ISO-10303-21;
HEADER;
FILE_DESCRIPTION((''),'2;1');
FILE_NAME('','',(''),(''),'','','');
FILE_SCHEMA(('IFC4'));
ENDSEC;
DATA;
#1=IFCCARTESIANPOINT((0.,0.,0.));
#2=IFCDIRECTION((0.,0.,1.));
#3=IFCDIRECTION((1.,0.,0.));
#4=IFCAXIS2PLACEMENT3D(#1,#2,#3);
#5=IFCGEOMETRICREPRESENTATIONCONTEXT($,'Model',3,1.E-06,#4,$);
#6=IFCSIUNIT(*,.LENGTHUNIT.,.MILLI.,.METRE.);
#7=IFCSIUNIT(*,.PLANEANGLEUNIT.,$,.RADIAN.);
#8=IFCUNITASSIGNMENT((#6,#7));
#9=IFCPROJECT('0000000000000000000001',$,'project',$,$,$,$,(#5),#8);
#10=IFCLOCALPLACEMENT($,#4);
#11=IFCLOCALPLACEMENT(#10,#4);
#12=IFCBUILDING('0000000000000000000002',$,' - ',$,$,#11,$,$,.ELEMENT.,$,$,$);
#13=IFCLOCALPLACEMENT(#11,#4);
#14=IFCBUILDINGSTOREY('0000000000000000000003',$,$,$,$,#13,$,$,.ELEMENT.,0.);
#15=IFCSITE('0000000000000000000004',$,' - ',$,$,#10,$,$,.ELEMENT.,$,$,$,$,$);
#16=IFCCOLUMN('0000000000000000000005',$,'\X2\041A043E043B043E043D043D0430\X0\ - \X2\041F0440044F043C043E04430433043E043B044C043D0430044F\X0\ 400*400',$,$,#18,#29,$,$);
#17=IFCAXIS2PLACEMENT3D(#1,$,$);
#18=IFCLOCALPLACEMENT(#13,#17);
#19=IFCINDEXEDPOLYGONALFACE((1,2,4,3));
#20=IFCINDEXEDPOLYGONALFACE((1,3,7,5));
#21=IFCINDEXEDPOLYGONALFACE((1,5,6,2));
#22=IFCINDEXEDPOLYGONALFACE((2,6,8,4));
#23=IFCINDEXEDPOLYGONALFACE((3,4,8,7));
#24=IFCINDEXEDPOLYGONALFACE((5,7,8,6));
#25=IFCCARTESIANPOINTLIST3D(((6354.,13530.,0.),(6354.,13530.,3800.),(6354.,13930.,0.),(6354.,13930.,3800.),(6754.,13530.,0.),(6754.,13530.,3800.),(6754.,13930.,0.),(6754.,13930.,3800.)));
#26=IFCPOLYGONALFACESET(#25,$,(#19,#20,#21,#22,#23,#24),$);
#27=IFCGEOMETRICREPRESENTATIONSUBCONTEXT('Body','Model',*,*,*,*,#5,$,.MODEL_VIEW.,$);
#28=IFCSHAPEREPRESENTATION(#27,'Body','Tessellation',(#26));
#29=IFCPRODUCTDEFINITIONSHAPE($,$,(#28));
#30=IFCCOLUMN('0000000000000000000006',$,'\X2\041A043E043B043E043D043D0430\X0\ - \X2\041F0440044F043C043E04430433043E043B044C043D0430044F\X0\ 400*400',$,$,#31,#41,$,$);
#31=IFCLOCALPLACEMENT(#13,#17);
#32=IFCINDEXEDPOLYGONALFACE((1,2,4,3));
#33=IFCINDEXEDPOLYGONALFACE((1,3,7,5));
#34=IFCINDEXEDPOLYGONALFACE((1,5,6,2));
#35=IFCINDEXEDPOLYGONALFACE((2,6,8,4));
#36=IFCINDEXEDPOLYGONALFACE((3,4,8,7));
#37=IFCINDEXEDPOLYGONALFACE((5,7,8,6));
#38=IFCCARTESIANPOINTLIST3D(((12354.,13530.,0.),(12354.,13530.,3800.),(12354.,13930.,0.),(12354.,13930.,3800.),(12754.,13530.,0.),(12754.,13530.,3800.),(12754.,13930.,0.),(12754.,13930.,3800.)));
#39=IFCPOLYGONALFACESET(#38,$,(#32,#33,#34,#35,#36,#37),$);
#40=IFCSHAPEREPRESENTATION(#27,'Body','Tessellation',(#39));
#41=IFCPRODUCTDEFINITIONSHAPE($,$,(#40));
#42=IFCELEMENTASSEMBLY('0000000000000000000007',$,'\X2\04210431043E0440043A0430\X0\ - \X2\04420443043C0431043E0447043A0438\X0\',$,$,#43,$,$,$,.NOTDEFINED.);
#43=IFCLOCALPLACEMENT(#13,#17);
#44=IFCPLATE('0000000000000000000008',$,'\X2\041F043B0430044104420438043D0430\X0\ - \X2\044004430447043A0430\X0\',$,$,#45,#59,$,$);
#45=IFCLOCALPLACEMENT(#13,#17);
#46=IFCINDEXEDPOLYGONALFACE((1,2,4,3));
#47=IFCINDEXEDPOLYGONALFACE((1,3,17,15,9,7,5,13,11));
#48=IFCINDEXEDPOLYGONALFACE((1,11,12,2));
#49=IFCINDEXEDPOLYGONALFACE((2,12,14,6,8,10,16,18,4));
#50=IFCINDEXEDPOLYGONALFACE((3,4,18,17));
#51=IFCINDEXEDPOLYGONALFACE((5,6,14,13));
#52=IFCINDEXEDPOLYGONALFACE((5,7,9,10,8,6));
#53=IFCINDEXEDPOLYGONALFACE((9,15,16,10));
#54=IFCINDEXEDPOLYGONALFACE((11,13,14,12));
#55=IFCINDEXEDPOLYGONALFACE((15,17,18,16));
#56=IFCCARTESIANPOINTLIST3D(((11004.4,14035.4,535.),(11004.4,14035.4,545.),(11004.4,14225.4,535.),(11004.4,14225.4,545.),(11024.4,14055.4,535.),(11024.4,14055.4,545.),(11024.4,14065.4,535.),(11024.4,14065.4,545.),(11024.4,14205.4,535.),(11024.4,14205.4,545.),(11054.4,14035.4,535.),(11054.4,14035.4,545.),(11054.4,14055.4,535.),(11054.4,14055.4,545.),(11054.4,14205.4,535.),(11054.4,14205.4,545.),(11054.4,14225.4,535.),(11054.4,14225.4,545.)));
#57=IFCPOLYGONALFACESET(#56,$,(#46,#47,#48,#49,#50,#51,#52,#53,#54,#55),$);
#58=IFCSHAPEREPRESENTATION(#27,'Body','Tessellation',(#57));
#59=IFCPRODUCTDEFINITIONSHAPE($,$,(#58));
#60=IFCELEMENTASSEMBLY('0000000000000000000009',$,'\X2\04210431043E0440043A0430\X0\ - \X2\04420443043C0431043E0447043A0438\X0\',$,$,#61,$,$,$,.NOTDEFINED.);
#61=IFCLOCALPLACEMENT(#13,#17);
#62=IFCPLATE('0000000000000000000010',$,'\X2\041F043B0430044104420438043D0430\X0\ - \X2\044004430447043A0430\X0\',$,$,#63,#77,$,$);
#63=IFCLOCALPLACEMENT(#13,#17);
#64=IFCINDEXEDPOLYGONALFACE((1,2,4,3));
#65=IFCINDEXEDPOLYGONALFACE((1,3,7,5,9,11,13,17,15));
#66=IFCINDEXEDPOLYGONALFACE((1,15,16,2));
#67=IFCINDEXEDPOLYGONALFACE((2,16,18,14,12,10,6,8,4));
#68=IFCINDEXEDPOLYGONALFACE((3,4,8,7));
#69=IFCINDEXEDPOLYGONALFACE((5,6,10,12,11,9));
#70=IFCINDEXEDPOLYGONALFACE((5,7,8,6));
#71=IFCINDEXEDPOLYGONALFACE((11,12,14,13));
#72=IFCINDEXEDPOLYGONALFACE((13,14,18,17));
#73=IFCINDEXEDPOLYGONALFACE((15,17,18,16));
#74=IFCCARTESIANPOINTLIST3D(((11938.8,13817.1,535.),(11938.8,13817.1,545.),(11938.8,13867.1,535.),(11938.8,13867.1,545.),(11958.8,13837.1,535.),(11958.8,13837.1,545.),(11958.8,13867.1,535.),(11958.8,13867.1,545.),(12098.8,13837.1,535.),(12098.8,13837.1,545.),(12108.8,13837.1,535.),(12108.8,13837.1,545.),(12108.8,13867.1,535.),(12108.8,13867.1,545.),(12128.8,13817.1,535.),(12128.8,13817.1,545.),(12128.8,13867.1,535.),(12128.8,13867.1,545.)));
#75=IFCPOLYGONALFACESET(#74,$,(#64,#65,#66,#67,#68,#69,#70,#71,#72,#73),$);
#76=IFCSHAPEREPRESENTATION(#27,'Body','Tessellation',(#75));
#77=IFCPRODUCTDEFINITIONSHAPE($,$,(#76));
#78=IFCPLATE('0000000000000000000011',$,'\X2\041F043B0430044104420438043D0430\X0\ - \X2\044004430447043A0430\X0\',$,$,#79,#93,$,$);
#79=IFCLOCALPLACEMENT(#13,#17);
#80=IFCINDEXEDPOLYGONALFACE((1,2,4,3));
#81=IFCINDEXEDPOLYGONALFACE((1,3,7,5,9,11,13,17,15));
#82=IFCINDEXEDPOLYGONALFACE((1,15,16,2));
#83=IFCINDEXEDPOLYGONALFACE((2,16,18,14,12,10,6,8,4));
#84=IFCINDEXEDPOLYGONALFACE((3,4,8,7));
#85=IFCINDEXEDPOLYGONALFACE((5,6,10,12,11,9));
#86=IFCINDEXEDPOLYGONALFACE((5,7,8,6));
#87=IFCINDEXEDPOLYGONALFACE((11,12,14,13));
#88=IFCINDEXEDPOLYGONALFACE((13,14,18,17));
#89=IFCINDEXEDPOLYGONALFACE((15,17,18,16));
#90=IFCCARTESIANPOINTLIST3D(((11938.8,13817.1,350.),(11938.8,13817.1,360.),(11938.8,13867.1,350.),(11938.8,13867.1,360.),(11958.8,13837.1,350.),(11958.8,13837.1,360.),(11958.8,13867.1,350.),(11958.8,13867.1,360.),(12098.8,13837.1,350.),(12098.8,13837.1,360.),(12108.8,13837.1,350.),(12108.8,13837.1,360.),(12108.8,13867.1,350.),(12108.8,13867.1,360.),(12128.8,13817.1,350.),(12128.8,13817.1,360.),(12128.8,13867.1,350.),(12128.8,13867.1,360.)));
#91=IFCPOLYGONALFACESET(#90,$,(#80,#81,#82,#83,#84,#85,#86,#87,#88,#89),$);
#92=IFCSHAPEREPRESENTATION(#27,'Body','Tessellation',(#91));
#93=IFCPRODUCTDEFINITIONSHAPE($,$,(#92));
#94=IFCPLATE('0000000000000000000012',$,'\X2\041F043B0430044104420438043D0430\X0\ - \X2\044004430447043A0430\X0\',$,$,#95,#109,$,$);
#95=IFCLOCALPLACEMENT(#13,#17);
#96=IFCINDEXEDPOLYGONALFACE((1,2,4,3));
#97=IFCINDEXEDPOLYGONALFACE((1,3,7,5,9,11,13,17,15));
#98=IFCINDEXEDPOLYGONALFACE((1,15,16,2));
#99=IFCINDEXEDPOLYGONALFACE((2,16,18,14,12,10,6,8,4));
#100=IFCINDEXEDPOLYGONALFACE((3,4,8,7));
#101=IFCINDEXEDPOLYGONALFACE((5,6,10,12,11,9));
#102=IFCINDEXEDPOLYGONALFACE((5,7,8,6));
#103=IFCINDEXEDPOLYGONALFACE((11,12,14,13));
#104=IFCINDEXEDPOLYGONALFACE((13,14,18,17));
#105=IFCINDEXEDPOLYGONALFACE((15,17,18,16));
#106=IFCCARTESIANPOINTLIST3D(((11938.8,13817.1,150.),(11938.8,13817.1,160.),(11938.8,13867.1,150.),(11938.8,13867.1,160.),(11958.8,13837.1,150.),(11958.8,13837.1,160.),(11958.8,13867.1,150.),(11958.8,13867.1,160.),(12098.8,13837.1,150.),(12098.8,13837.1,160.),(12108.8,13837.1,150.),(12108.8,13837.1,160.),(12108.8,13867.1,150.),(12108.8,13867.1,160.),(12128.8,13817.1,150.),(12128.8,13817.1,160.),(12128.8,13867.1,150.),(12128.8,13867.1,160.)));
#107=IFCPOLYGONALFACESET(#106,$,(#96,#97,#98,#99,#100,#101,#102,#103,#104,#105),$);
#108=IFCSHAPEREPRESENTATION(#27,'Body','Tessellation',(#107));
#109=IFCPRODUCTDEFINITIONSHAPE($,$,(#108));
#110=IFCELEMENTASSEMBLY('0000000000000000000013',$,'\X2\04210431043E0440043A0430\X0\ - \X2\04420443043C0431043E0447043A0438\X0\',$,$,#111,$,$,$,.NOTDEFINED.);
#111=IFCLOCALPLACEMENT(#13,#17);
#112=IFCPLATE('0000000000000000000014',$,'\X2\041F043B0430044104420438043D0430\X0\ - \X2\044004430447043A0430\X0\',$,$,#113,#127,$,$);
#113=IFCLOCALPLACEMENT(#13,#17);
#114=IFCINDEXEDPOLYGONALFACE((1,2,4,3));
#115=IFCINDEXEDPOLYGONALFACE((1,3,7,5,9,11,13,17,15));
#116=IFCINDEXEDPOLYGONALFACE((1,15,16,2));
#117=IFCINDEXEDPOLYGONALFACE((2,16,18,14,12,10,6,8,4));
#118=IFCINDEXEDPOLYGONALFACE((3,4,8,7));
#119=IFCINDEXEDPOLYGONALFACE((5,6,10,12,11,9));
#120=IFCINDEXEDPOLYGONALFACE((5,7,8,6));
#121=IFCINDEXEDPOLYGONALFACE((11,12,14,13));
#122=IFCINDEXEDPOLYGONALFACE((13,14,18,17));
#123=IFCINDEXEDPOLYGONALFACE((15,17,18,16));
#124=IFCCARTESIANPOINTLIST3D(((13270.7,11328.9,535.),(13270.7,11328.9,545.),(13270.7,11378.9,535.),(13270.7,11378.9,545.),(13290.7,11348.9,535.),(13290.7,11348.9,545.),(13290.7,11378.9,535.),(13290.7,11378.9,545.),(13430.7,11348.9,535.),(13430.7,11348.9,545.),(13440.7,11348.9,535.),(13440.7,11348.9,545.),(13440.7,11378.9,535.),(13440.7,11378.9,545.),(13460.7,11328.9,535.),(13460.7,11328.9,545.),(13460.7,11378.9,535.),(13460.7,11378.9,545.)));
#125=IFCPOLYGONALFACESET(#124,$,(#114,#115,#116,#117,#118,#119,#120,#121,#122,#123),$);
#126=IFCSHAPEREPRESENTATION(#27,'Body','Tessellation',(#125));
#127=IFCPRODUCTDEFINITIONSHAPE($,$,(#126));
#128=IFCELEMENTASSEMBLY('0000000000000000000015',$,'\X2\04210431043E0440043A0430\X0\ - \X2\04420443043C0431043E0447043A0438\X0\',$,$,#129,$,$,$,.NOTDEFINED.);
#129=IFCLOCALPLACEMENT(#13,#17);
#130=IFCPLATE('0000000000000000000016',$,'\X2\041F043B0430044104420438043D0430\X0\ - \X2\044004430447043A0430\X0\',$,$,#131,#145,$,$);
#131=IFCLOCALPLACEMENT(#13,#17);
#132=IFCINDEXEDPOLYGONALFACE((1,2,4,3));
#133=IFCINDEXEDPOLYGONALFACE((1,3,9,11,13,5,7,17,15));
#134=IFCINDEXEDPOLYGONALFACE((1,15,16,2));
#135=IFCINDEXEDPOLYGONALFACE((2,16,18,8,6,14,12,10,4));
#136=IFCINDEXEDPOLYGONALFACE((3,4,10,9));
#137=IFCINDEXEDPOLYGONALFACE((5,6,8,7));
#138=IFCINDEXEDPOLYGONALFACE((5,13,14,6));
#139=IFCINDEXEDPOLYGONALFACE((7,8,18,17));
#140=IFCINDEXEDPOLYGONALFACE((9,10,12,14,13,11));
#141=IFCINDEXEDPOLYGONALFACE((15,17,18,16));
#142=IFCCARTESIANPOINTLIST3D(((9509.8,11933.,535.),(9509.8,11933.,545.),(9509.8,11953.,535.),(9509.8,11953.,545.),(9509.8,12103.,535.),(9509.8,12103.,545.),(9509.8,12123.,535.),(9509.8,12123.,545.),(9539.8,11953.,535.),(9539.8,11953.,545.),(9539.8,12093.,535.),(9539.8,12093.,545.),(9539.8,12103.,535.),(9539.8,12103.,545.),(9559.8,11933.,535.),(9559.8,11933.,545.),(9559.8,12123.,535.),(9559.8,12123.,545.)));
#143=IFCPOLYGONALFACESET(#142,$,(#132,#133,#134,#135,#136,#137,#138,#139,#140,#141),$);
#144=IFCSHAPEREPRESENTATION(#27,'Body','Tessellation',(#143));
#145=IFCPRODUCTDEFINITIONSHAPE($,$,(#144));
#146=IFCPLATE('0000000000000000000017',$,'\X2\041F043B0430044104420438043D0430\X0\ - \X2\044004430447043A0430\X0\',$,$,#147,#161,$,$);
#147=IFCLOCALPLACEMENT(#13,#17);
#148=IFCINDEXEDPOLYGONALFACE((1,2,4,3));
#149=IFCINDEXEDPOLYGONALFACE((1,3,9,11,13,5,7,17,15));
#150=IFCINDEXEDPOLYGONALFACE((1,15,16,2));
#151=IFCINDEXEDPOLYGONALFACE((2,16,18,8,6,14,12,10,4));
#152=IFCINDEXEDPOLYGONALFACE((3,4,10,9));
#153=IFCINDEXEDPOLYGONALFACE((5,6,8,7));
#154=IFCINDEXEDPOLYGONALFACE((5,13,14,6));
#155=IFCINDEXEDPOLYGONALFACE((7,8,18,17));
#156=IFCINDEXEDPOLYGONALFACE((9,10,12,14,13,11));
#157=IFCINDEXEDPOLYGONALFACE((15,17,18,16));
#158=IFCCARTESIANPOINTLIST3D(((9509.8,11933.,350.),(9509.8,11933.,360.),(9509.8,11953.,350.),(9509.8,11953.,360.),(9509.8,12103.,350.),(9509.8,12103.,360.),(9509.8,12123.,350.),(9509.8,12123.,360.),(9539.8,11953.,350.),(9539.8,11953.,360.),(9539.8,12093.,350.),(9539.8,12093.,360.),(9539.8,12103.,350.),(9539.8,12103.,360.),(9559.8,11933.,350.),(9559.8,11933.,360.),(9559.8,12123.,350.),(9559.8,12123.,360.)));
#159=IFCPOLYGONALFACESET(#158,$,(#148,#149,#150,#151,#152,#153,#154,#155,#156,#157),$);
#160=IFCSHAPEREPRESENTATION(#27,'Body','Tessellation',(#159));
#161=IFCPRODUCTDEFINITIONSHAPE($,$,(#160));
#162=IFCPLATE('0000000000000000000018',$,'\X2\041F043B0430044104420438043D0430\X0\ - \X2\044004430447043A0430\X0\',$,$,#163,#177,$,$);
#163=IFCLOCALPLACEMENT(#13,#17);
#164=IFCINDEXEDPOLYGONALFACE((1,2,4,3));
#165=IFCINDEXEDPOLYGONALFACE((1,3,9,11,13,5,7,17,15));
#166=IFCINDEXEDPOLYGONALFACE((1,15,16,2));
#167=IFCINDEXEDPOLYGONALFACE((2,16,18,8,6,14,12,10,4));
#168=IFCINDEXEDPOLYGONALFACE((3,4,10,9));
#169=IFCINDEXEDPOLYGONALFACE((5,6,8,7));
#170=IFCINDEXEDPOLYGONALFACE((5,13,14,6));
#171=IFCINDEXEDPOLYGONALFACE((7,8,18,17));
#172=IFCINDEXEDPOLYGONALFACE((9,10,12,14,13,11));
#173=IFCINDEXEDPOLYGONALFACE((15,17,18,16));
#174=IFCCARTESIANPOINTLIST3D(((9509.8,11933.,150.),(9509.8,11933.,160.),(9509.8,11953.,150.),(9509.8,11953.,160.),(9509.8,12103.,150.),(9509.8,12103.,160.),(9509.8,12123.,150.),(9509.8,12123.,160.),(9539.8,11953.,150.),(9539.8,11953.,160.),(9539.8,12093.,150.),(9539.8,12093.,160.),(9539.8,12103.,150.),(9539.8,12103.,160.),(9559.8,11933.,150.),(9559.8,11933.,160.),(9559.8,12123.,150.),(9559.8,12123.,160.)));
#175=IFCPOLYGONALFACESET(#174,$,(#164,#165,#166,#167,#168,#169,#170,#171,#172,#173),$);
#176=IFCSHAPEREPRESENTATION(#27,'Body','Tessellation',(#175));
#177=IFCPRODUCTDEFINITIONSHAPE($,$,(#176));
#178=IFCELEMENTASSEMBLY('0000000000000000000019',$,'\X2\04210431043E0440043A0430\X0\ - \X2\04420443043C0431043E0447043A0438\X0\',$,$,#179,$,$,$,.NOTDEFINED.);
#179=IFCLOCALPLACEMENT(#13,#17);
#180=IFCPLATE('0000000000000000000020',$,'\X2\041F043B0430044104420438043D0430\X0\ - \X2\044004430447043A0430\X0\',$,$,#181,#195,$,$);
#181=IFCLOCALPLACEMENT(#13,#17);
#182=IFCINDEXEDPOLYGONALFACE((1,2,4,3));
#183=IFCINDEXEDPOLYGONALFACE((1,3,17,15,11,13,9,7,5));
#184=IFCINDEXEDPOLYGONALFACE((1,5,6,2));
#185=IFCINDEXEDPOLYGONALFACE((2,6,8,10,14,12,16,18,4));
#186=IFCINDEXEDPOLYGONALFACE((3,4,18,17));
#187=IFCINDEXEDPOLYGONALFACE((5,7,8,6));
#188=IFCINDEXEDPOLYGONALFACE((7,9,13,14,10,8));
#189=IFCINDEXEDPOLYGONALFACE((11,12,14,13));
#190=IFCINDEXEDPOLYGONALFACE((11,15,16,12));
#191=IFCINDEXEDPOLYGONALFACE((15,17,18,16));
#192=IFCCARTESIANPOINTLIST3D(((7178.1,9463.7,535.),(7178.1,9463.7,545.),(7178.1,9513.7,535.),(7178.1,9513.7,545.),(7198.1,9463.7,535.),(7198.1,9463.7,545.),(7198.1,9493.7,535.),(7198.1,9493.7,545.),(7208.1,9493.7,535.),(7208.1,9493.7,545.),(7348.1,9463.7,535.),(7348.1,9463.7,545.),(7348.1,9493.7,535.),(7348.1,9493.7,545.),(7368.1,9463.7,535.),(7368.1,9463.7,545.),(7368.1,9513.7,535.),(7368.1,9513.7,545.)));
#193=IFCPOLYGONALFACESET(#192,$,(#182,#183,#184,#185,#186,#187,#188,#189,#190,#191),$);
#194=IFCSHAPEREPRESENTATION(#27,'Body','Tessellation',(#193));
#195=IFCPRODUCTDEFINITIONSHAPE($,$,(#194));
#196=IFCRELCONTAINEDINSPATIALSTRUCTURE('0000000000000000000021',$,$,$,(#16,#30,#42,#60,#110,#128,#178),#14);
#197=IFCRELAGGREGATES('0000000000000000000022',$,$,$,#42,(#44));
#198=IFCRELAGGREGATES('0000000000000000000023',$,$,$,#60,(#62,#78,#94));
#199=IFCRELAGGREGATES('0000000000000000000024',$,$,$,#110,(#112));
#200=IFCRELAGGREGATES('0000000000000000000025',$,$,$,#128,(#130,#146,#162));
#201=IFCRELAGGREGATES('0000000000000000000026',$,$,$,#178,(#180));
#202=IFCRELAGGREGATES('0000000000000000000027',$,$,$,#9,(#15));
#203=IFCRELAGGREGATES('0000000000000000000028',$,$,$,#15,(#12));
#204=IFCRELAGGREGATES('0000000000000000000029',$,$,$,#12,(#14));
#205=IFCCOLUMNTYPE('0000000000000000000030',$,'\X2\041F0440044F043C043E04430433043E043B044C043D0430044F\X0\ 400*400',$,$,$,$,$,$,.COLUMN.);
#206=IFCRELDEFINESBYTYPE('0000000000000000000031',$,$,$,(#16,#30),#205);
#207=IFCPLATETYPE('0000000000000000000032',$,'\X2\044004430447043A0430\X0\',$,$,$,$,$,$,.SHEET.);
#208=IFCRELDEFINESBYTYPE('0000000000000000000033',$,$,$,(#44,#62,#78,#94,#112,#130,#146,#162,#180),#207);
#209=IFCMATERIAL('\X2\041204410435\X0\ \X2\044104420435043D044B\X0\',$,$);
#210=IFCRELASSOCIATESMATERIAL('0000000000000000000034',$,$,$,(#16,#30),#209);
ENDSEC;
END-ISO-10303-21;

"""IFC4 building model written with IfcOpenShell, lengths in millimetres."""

from ifc_helpers import new_model, si_unit, frame, origin_with_axes, place, context, subcontext, project, spatial, line, indexed_curve, outline, extrude, source, transform, mapped, material, type_object, element, aggregate, save


model = new_model("IFC4")

# Units and contexts
model_context = context("Model", 3, precision=1e-06, world=origin_with_axes())
body_context = subcontext(model_context, "Body", "Model", "MODEL_VIEW")
ifc_project = project(units=[si_unit("LENGTHUNIT", "METRE", prefix="MILLI"), si_unit("PLANEANGLEUNIT", "RADIAN")], contexts=[model_context])

# Site, building, storey
site_placement = place(None, origin_with_axes())
site = spatial("IfcSite", under=ifc_project, at=site_placement, Name=" - ", CompositionType="ELEMENT")
building_placement = place(site_placement, origin_with_axes())
building = spatial("IfcBuilding", under=site, at=building_placement, Name=" - ", CompositionType="ELEMENT")
storey_placement = place(building_placement, origin_with_axes())
storey = spatial("IfcBuildingStorey", under=building, at=storey_placement, CompositionType="ELEMENT", Elevation=0.0)

# Columns
ifc_material = material(Name="Все стены")
column_type = type_object("IfcColumnType", Name="Прямоугольная 400*400", PredefinedType="COLUMN")
shared_shape_1 = source(origin_with_axes(), body_context, "Body", "SweptSolid", [
    extrude(outline(indexed_curve([(-200.0, -200.0), (200.0, -200.0), (200.0, 200.0), (-200.0, 200.0)], segments=[line(1, 2), line(2, 3), line(3, 4), line(4, 1)])), origin_with_axes(), (0.0, 0.0, 1.0), 3800.0),
])
for number, where, z_axis, x_axis, name in (
    (1, (6554.0, 13730.0, 0.0), (0.0, 0.0, 1.0), (1.0, 0.0, 0.0), "Колонна - Прямоугольная 400*400"),
    (2, (12554.0, 13730.0, 0.0), (0.0, 0.0, 1.0), (1.0, 0.0, 0.0), "Колонна - Прямоугольная 400*400"),
):
    element("IfcColumn", number, at=place(storey_placement, frame(where, z_axis=z_axis, x_axis=x_axis)), inside=storey, type_object=column_type, material=ifc_material, Name=name, context=body_context, shape_type="MappedRepresentation", body=[
        mapped(shared_shape_1, transform((0.0, 0.0, 0.0), x_axis=(1.0, 0.0, 0.0), y_axis=(0.0, 1.0, 0.0), z_axis=(0.0, 0.0, 1.0), scale=1.0)),
    ])

# Element assembly, plate
assembly_1_placement = place(storey_placement, frame((11054.4, 14330.4, 0.0), z_axis=(0.0, 0.0, 1.0), x_axis=(0.0, -1.0, 0.0)))
assembly_1 = element("IfcElementAssembly", 3, at=assembly_1_placement, inside=storey, Name="Сборка - тумбочки", PredefinedType="NOTDEFINED")
plate_type = type_object("IfcPlateType", Name="ручка", PredefinedType="SHEET")
shared_shape_2 = source(origin_with_axes(), body_context, "Body", "SweptSolid", [
    extrude(outline(indexed_curve([(-95.0, -25.0), (-75.0, -25.0), (-75.0, 5.0), (-65.0, 5.0), (75.0, 5.0), (75.0, -25.0), (95.0, -25.0), (95.0, 25.0), (-95.0, 25.0)], segments=[line(1, 2), line(2, 3), line(3, 4), line(4, 5), line(5, 6), line(6, 7), line(7, 8), line(8, 9), line(9, 1)])), origin_with_axes(), (0.0, 0.0, 1.0), 10.0),
])
plate_1_placement = place(assembly_1_placement, frame((200.0, -25.0, 535.0), z_axis=(0.0, 0.0, 1.0), x_axis=(-1.0, 0.0, 0.0)))
plate_1 = element("IfcPlate", 4, at=plate_1_placement, type_object=plate_type, Name="Пластина - ручка", context=body_context, shape_type="MappedRepresentation", body=[
    mapped(shared_shape_2, transform((0.0, 0.0, 0.0), x_axis=(1.0, 0.0, 0.0), y_axis=(0.0, 1.0, 0.0), z_axis=(0.0, 0.0, 1.0), scale=1.0)),
])
aggregate(assembly_1, [plate_1])

# Element assembly, plates
assembly_2_placement = place(storey_placement, frame((11833.8, 13867.1, 0.0), z_axis=(0.0, 0.0, 1.0), x_axis=(1.0, 0.0, 0.0)))
assembly_2 = element("IfcElementAssembly", 5, at=assembly_2_placement, inside=storey, Name="Сборка - тумбочки", PredefinedType="NOTDEFINED")
plate_2_placement = place(assembly_2_placement, frame((200.0, -25.0, 535.0), z_axis=(0.0, 0.0, 1.0), x_axis=(-1.0, 0.0, 0.0)))
plate_2 = element("IfcPlate", 6, at=plate_2_placement, type_object=plate_type, Name="Пластина - ручка", context=body_context, shape_type="MappedRepresentation", body=[
    mapped(shared_shape_2, transform((0.0, 0.0, 0.0), x_axis=(1.0, 0.0, 0.0), y_axis=(0.0, 1.0, 0.0), z_axis=(0.0, 0.0, 1.0), scale=1.0)),
])
plate_3_placement = place(assembly_2_placement, frame((200.0, -25.0, 350.0), z_axis=(0.0, 0.0, 1.0), x_axis=(-1.0, 0.0, 0.0)))
plate_3 = element("IfcPlate", 7, at=plate_3_placement, type_object=plate_type, Name="Пластина - ручка", context=body_context, shape_type="MappedRepresentation", body=[
    mapped(shared_shape_2, transform((0.0, 0.0, 0.0), x_axis=(1.0, 0.0, 0.0), y_axis=(0.0, 1.0, 0.0), z_axis=(0.0, 0.0, 1.0), scale=1.0)),
])
plate_4_placement = place(assembly_2_placement, frame((200.0, -25.0, 150.0), z_axis=(0.0, 0.0, 1.0), x_axis=(-1.0, 0.0, 0.0)))
plate_4 = element("IfcPlate", 8, at=plate_4_placement, type_object=plate_type, Name="Пластина - ручка", context=body_context, shape_type="MappedRepresentation", body=[
    mapped(shared_shape_2, transform((0.0, 0.0, 0.0), x_axis=(1.0, 0.0, 0.0), y_axis=(0.0, 1.0, 0.0), z_axis=(0.0, 0.0, 1.0), scale=1.0)),
])
aggregate(assembly_2, [plate_2, plate_3, plate_4])

# Element assembly, plate
assembly_3_placement = place(storey_placement, frame((13165.7, 11378.9, 0.0), z_axis=(0.0, 0.0, 1.0), x_axis=(1.0, 0.0, 0.0)))
assembly_3 = element("IfcElementAssembly", 9, at=assembly_3_placement, inside=storey, Name="Сборка - тумбочки", PredefinedType="NOTDEFINED")
plate_5_placement = place(assembly_3_placement, frame((200.0, -25.0, 535.0), z_axis=(0.0, 0.0, 1.0), x_axis=(-1.0, 0.0, 0.0)))
plate_5 = element("IfcPlate", 10, at=plate_5_placement, type_object=plate_type, Name="Пластина - ручка", context=body_context, shape_type="MappedRepresentation", body=[
    mapped(shared_shape_2, transform((0.0, 0.0, 0.0), x_axis=(1.0, 0.0, 0.0), y_axis=(0.0, 1.0, 0.0), z_axis=(0.0, 0.0, 1.0), scale=1.0)),
])
aggregate(assembly_3, [plate_5])

# Element assemblies, plates
assembly_4_placement = place(storey_placement, frame((9509.8, 11828.0, 0.0), z_axis=(0.0, 0.0, 1.0), x_axis=(0.0, 1.0, 0.0)))
assembly_4 = element("IfcElementAssembly", 11, at=assembly_4_placement, inside=storey, Name="Сборка - тумбочки", PredefinedType="NOTDEFINED")
plate_6_placement = place(assembly_4_placement, frame((200.0, -25.0, 535.0), z_axis=(0.0, 0.0, 1.0), x_axis=(-1.0, 0.0, 0.0)))
plate_6 = element("IfcPlate", 12, at=plate_6_placement, type_object=plate_type, Name="Пластина - ручка", context=body_context, shape_type="MappedRepresentation", body=[
    mapped(shared_shape_2, transform((0.0, 0.0, 0.0), x_axis=(1.0, 0.0, 0.0), y_axis=(0.0, 1.0, 0.0), z_axis=(0.0, 0.0, 1.0), scale=1.0)),
])
plate_7_placement = place(assembly_4_placement, frame((200.0, -25.0, 350.0), z_axis=(0.0, 0.0, 1.0), x_axis=(-1.0, 0.0, 0.0)))
plate_7 = element("IfcPlate", 13, at=plate_7_placement, type_object=plate_type, Name="Пластина - ручка", context=body_context, shape_type="MappedRepresentation", body=[
    mapped(shared_shape_2, transform((0.0, 0.0, 0.0), x_axis=(1.0, 0.0, 0.0), y_axis=(0.0, 1.0, 0.0), z_axis=(0.0, 0.0, 1.0), scale=1.0)),
])
plate_8_placement = place(assembly_4_placement, frame((200.0, -25.0, 150.0), z_axis=(0.0, 0.0, 1.0), x_axis=(-1.0, 0.0, 0.0)))
plate_8 = element("IfcPlate", 14, at=plate_8_placement, type_object=plate_type, Name="Пластина - ручка", context=body_context, shape_type="MappedRepresentation", body=[
    mapped(shared_shape_2, transform((0.0, 0.0, 0.0), x_axis=(1.0, 0.0, 0.0), y_axis=(0.0, 1.0, 0.0), z_axis=(0.0, 0.0, 1.0), scale=1.0)),
])
aggregate(assembly_4, [plate_6, plate_7, plate_8])
assembly_5_placement = place(storey_placement, frame((7473.1, 9463.7, 0.0), z_axis=(0.0, 0.0, 1.0), x_axis=(-1.0, 0.0, 0.0)))
assembly_5 = element("IfcElementAssembly", 15, at=assembly_5_placement, inside=storey, Name="Сборка - тумбочки", PredefinedType="NOTDEFINED")
plate_9_placement = place(assembly_5_placement, frame((200.0, -25.0, 535.0), z_axis=(0.0, 0.0, 1.0), x_axis=(-1.0, 0.0, 0.0)))
plate_9 = element("IfcPlate", 16, at=plate_9_placement, type_object=plate_type, Name="Пластина - ручка", context=body_context, shape_type="MappedRepresentation", body=[
    mapped(shared_shape_2, transform((0.0, 0.0, 0.0), x_axis=(1.0, 0.0, 0.0), y_axis=(0.0, 1.0, 0.0), z_axis=(0.0, 0.0, 1.0), scale=1.0)),
])
aggregate(assembly_5, [plate_9])

save(model, "model.ifc")
